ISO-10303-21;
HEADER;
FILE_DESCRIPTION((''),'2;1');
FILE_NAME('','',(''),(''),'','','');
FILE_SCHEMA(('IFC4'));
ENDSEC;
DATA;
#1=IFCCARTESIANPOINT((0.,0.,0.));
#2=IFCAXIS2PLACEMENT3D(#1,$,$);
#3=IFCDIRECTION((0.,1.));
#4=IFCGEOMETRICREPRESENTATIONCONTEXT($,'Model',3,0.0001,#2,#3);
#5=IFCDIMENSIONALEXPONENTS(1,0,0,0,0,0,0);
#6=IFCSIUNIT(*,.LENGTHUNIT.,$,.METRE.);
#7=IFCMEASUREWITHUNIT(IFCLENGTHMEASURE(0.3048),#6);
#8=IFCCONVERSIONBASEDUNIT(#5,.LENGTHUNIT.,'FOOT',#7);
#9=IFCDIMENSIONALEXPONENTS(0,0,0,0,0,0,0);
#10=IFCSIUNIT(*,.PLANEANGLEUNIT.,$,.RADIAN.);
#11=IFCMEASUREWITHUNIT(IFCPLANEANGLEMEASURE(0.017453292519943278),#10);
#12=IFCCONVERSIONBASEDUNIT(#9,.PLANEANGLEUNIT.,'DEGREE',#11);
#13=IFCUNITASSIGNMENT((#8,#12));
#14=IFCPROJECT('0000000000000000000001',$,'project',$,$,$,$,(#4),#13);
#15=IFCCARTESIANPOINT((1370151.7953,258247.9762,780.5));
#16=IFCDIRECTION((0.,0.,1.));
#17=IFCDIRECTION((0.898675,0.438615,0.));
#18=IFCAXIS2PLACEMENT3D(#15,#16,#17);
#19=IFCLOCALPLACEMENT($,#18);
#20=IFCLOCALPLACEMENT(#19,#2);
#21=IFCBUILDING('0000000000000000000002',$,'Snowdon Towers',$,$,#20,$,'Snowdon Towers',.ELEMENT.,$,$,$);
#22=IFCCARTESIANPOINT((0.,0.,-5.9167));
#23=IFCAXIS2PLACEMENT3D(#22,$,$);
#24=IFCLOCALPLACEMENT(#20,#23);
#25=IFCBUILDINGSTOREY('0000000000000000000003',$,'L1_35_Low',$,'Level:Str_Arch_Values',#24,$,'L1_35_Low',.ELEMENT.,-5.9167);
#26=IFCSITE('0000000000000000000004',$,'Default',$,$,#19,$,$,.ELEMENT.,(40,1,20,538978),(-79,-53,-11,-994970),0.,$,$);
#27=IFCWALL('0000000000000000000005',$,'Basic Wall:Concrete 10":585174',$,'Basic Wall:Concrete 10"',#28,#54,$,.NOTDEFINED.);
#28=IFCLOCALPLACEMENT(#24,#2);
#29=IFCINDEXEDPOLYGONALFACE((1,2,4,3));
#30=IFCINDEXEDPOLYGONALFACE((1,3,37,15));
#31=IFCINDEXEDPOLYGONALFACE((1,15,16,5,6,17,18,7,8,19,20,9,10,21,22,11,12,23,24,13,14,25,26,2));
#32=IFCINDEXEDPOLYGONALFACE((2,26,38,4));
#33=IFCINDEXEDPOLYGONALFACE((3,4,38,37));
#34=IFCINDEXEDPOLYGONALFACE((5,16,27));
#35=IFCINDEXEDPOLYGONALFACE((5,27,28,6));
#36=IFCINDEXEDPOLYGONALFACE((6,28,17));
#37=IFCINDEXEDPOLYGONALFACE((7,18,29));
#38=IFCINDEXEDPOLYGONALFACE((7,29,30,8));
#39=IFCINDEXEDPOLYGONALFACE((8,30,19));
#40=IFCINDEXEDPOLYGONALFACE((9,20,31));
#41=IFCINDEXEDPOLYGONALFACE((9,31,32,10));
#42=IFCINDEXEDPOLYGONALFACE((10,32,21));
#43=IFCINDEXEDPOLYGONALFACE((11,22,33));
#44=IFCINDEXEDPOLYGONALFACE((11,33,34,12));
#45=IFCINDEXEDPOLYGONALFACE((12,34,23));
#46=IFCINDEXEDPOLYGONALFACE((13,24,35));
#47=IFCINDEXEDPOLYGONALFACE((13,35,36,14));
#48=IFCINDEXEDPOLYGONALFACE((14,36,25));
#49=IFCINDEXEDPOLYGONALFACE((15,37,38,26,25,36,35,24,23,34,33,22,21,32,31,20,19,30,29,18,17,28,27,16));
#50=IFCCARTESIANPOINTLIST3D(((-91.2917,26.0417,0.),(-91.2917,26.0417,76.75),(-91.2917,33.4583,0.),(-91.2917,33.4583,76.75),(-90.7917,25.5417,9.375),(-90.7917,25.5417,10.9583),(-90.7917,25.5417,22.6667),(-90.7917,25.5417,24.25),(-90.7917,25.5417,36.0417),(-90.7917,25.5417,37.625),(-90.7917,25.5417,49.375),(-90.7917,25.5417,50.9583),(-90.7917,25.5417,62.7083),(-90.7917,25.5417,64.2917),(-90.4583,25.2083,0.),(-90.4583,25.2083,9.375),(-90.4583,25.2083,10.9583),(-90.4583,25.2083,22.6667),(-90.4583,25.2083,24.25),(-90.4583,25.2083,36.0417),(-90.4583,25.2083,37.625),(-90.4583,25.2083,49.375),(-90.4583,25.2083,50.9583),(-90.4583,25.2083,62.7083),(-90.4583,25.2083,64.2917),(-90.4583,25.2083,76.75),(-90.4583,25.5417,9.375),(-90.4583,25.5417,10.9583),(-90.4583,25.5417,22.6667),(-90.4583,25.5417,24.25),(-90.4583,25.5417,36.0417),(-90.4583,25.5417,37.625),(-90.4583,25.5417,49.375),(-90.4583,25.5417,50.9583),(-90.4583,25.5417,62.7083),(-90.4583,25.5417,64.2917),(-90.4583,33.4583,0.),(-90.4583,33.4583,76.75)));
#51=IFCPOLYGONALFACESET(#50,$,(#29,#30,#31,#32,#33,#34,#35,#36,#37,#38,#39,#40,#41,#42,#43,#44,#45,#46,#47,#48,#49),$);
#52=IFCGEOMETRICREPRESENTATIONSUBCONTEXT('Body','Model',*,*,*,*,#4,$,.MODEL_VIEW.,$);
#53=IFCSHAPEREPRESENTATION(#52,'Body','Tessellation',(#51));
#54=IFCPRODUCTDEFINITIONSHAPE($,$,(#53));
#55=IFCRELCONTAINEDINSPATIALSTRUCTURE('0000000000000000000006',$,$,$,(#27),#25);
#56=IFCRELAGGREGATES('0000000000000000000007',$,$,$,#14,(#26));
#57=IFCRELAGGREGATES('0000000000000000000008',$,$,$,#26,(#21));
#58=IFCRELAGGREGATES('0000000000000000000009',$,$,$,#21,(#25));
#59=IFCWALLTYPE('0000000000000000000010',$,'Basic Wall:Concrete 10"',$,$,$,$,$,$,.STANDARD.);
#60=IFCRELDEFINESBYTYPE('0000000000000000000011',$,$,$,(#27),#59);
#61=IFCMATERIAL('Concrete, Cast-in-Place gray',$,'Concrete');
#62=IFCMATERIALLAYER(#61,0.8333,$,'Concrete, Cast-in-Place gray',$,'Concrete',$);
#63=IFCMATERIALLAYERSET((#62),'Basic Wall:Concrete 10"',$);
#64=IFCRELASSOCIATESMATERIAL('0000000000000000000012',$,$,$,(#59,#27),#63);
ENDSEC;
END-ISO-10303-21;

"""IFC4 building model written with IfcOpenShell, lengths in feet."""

from ifc_helpers import new_model, entity, si_unit, converted_unit, direction, frame, frame_2d, origin, place, context, subcontext, project, spatial, polyline, rectangle, outline, extrude, material, layer, layer_set, layer_usage, type_object, element, save


model = new_model("IFC4")

# Units and contexts
model_context = context("Model", 3, precision=0.0001, world=origin(), true_north=direction((0.0, 1.0)))
body_context = subcontext(model_context, "Body", "Model", "MODEL_VIEW")
ifc_project = project(units=[converted_unit("LENGTHUNIT", "FOOT", entity("IfcLengthMeasure", 0.3048), si_unit("LENGTHUNIT", "METRE"), dimensions=[1, 0, 0, 0, 0, 0, 0]), converted_unit("PLANEANGLEUNIT", "DEGREE", entity("IfcPlaneAngleMeasure", 0.017453292519943278), si_unit("PLANEANGLEUNIT", "RADIAN"), dimensions=[0, 0, 0, 0, 0, 0, 0])], contexts=[model_context])

# Site, building, storey
site_placement = place(None, frame((1370151.7953, 258247.9762, 780.5), z_axis=(0.0, 0.0, 1.0), x_axis=(0.898675, 0.438615, 0.0)))
site = spatial("IfcSite", under=ifc_project, at=site_placement, Name="Default", CompositionType="ELEMENT", RefLatitude=(40, 1, 20, 538978), RefLongitude=(-79, -53, -11, -994970), RefElevation=0.0)
building_placement = place(site_placement, origin())
building = spatial("IfcBuilding", under=site, at=building_placement, Name="Snowdon Towers", LongName="Snowdon Towers", CompositionType="ELEMENT")
storey_placement = place(building_placement, frame((0.0, 0.0, -5.9167)))
storey = spatial("IfcBuildingStorey", under=building, at=storey_placement, Name="L1_35_Low", ObjectType="Level:Str_Arch_Values", LongName="L1_35_Low", CompositionType="ELEMENT", Elevation=-5.9167)

# Wall, openings
ifc_material = material(Name="Concrete, Cast-in-Place gray", Category="Concrete")
ifc_layer = layer(ifc_material, 0.8333, Name="Concrete, Cast-in-Place gray", Category="Concrete")
ifc_layer_set = layer_set([ifc_layer], Name="Basic Wall:Concrete 10\"")
wall_type = type_object("IfcWallType", Name="Basic Wall:Concrete 10\"", PredefinedType="STANDARD", material=ifc_layer_set)
ifc_layer_usage_1 = layer_usage(ifc_layer_set, "AXIS2", "POSITIVE", -0.4167)
wall_1_placement = place(storey_placement, frame((-90.875, 33.4583, 0.0), z_axis=(0.0, 0.0, 1.0), x_axis=(0.0, -1.0, 0.0)))
wall_1 = element("IfcWall", 1, at=wall_1_placement, inside=storey, type_object=wall_type, material=ifc_layer_usage_1, Name="Basic Wall:Concrete 10\":585174", ObjectType="Basic Wall:Concrete 10\"", PredefinedType="NOTDEFINED", context=body_context, shape_type="SweptSolid", body=[
    extrude(outline(polyline([(7.4167, -0.4167), (8.25, 0.4167), (0.0, 0.4167), (0.0, -0.4167), (7.4167, -0.4167)])), origin(), (0.0, 0.0, 1.0), 76.75),
])
opening_1_placement = place(wall_1_placement, origin())
element("IfcOpeningElement", 2, at=opening_1_placement, cuts=wall_1, PredefinedType="OPENING", context=body_context, shape_type="SweptSolid", body=[
    extrude(rectangle(XDim=1.5833, YDim=0.3333, at=frame_2d((0.0, 0.0), x_axis=(0.0, 1.0))), frame((8.0833, -0.5, 23.4583), z_axis=(0.0, 1.0, 0.0), x_axis=(1.0, 0.0, 0.0)), (0.0, 0.0, 1.0), 1.0),
])
opening_2_placement = place(wall_1_placement, origin())
element("IfcOpeningElement", 3, at=opening_2_placement, cuts=wall_1, PredefinedType="OPENING", context=body_context, shape_type="SweptSolid", body=[
    extrude(rectangle(XDim=1.5833, YDim=0.3333, at=frame_2d((0.0, 0.0), x_axis=(0.0, 1.0))), frame((8.0833, -0.5, 10.1667), z_axis=(0.0, 1.0, 0.0), x_axis=(1.0, 0.0, 0.0)), (0.0, 0.0, 1.0), 1.0),
])
opening_3_placement = place(wall_1_placement, origin())
element("IfcOpeningElement", 4, at=opening_3_placement, cuts=wall_1, PredefinedType="OPENING", context=body_context, shape_type="SweptSolid", body=[
    extrude(rectangle(XDim=1.5833, YDim=0.3333, at=frame_2d((0.0, 0.0), x_axis=(0.0, 1.0))), frame((8.0833, -0.5, 63.5), z_axis=(0.0, 1.0, 0.0), x_axis=(1.0, 0.0, 0.0)), (0.0, 0.0, 1.0), 1.0),
])
opening_4_placement = place(wall_1_placement, origin())
element("IfcOpeningElement", 5, at=opening_4_placement, cuts=wall_1, PredefinedType="OPENING", context=body_context, shape_type="SweptSolid", body=[
    extrude(rectangle(XDim=1.5833, YDim=0.3333, at=frame_2d((0.0, 0.0), x_axis=(0.0, 1.0))), frame((8.0833, -0.5, 36.8333), z_axis=(0.0, 1.0, 0.0), x_axis=(1.0, 0.0, 0.0)), (0.0, 0.0, 1.0), 1.0),
])
opening_5_placement = place(wall_1_placement, origin())
element("IfcOpeningElement", 6, at=opening_5_placement, cuts=wall_1, PredefinedType="OPENING", context=body_context, shape_type="SweptSolid", body=[
    extrude(rectangle(XDim=1.5833, YDim=0.3333, at=frame_2d((0.0, 0.0), x_axis=(0.0, 1.0))), frame((8.0833, -0.5, 50.1667), z_axis=(0.0, 1.0, 0.0), x_axis=(1.0, 0.0, 0.0)), (0.0, 0.0, 1.0), 1.0),
])
opening_6_placement = place(wall_1_placement, origin())
element("IfcOpeningElement", 7, at=opening_6_placement, cuts=wall_1, PredefinedType="OPENING", context=body_context, shape_type="SweptSolid", body=[
    extrude(rectangle(XDim=1.5833, YDim=0.3333, at=frame_2d((0.0, 0.0), x_axis=(0.0, 1.0))), frame((-0.6667, -0.5, 23.4583), z_axis=(0.0, 1.0, 0.0), x_axis=(-1.0, 0.0, 0.0)), (0.0, 0.0, 1.0), 1.0),
])
opening_7_placement = place(wall_1_placement, origin())
element("IfcOpeningElement", 8, at=opening_7_placement, cuts=wall_1, PredefinedType="OPENING", context=body_context, shape_type="SweptSolid", body=[
    extrude(rectangle(XDim=1.5833, YDim=0.3333, at=frame_2d((0.0, 0.0), x_axis=(0.0, 1.0))), frame((-0.6667, -0.5, 10.1667), z_axis=(0.0, 1.0, 0.0), x_axis=(-1.0, 0.0, 0.0)), (0.0, 0.0, 1.0), 1.0),
])
opening_8_placement = place(wall_1_placement, origin())
element("IfcOpeningElement", 9, at=opening_8_placement, cuts=wall_1, PredefinedType="OPENING", context=body_context, shape_type="SweptSolid", body=[
    extrude(rectangle(XDim=1.5833, YDim=0.3333, at=frame_2d((0.0, 0.0), x_axis=(0.0, 1.0))), frame((-0.6667, -0.5, 63.5), z_axis=(0.0, 1.0, 0.0), x_axis=(-1.0, 0.0, 0.0)), (0.0, 0.0, 1.0), 1.0),
])
opening_9_placement = place(wall_1_placement, origin())
element("IfcOpeningElement", 10, at=opening_9_placement, cuts=wall_1, PredefinedType="OPENING", context=body_context, shape_type="SweptSolid", body=[
    extrude(rectangle(XDim=1.5833, YDim=0.3333, at=frame_2d((0.0, 0.0), x_axis=(0.0, 1.0))), frame((-0.6667, -0.5, 36.8333), z_axis=(0.0, 1.0, 0.0), x_axis=(-1.0, 0.0, 0.0)), (0.0, 0.0, 1.0), 1.0),
])
opening_10_placement = place(wall_1_placement, origin())
element("IfcOpeningElement", 11, at=opening_10_placement, cuts=wall_1, PredefinedType="OPENING", context=body_context, shape_type="SweptSolid", body=[
    extrude(rectangle(XDim=1.5833, YDim=0.3333, at=frame_2d((0.0, 0.0), x_axis=(0.0, 1.0))), frame((-0.6667, -0.5, 50.1667), z_axis=(0.0, 1.0, 0.0), x_axis=(-1.0, 0.0, 0.0)), (0.0, 0.0, 1.0), 1.0),
])

save(model, "model.ifc")
